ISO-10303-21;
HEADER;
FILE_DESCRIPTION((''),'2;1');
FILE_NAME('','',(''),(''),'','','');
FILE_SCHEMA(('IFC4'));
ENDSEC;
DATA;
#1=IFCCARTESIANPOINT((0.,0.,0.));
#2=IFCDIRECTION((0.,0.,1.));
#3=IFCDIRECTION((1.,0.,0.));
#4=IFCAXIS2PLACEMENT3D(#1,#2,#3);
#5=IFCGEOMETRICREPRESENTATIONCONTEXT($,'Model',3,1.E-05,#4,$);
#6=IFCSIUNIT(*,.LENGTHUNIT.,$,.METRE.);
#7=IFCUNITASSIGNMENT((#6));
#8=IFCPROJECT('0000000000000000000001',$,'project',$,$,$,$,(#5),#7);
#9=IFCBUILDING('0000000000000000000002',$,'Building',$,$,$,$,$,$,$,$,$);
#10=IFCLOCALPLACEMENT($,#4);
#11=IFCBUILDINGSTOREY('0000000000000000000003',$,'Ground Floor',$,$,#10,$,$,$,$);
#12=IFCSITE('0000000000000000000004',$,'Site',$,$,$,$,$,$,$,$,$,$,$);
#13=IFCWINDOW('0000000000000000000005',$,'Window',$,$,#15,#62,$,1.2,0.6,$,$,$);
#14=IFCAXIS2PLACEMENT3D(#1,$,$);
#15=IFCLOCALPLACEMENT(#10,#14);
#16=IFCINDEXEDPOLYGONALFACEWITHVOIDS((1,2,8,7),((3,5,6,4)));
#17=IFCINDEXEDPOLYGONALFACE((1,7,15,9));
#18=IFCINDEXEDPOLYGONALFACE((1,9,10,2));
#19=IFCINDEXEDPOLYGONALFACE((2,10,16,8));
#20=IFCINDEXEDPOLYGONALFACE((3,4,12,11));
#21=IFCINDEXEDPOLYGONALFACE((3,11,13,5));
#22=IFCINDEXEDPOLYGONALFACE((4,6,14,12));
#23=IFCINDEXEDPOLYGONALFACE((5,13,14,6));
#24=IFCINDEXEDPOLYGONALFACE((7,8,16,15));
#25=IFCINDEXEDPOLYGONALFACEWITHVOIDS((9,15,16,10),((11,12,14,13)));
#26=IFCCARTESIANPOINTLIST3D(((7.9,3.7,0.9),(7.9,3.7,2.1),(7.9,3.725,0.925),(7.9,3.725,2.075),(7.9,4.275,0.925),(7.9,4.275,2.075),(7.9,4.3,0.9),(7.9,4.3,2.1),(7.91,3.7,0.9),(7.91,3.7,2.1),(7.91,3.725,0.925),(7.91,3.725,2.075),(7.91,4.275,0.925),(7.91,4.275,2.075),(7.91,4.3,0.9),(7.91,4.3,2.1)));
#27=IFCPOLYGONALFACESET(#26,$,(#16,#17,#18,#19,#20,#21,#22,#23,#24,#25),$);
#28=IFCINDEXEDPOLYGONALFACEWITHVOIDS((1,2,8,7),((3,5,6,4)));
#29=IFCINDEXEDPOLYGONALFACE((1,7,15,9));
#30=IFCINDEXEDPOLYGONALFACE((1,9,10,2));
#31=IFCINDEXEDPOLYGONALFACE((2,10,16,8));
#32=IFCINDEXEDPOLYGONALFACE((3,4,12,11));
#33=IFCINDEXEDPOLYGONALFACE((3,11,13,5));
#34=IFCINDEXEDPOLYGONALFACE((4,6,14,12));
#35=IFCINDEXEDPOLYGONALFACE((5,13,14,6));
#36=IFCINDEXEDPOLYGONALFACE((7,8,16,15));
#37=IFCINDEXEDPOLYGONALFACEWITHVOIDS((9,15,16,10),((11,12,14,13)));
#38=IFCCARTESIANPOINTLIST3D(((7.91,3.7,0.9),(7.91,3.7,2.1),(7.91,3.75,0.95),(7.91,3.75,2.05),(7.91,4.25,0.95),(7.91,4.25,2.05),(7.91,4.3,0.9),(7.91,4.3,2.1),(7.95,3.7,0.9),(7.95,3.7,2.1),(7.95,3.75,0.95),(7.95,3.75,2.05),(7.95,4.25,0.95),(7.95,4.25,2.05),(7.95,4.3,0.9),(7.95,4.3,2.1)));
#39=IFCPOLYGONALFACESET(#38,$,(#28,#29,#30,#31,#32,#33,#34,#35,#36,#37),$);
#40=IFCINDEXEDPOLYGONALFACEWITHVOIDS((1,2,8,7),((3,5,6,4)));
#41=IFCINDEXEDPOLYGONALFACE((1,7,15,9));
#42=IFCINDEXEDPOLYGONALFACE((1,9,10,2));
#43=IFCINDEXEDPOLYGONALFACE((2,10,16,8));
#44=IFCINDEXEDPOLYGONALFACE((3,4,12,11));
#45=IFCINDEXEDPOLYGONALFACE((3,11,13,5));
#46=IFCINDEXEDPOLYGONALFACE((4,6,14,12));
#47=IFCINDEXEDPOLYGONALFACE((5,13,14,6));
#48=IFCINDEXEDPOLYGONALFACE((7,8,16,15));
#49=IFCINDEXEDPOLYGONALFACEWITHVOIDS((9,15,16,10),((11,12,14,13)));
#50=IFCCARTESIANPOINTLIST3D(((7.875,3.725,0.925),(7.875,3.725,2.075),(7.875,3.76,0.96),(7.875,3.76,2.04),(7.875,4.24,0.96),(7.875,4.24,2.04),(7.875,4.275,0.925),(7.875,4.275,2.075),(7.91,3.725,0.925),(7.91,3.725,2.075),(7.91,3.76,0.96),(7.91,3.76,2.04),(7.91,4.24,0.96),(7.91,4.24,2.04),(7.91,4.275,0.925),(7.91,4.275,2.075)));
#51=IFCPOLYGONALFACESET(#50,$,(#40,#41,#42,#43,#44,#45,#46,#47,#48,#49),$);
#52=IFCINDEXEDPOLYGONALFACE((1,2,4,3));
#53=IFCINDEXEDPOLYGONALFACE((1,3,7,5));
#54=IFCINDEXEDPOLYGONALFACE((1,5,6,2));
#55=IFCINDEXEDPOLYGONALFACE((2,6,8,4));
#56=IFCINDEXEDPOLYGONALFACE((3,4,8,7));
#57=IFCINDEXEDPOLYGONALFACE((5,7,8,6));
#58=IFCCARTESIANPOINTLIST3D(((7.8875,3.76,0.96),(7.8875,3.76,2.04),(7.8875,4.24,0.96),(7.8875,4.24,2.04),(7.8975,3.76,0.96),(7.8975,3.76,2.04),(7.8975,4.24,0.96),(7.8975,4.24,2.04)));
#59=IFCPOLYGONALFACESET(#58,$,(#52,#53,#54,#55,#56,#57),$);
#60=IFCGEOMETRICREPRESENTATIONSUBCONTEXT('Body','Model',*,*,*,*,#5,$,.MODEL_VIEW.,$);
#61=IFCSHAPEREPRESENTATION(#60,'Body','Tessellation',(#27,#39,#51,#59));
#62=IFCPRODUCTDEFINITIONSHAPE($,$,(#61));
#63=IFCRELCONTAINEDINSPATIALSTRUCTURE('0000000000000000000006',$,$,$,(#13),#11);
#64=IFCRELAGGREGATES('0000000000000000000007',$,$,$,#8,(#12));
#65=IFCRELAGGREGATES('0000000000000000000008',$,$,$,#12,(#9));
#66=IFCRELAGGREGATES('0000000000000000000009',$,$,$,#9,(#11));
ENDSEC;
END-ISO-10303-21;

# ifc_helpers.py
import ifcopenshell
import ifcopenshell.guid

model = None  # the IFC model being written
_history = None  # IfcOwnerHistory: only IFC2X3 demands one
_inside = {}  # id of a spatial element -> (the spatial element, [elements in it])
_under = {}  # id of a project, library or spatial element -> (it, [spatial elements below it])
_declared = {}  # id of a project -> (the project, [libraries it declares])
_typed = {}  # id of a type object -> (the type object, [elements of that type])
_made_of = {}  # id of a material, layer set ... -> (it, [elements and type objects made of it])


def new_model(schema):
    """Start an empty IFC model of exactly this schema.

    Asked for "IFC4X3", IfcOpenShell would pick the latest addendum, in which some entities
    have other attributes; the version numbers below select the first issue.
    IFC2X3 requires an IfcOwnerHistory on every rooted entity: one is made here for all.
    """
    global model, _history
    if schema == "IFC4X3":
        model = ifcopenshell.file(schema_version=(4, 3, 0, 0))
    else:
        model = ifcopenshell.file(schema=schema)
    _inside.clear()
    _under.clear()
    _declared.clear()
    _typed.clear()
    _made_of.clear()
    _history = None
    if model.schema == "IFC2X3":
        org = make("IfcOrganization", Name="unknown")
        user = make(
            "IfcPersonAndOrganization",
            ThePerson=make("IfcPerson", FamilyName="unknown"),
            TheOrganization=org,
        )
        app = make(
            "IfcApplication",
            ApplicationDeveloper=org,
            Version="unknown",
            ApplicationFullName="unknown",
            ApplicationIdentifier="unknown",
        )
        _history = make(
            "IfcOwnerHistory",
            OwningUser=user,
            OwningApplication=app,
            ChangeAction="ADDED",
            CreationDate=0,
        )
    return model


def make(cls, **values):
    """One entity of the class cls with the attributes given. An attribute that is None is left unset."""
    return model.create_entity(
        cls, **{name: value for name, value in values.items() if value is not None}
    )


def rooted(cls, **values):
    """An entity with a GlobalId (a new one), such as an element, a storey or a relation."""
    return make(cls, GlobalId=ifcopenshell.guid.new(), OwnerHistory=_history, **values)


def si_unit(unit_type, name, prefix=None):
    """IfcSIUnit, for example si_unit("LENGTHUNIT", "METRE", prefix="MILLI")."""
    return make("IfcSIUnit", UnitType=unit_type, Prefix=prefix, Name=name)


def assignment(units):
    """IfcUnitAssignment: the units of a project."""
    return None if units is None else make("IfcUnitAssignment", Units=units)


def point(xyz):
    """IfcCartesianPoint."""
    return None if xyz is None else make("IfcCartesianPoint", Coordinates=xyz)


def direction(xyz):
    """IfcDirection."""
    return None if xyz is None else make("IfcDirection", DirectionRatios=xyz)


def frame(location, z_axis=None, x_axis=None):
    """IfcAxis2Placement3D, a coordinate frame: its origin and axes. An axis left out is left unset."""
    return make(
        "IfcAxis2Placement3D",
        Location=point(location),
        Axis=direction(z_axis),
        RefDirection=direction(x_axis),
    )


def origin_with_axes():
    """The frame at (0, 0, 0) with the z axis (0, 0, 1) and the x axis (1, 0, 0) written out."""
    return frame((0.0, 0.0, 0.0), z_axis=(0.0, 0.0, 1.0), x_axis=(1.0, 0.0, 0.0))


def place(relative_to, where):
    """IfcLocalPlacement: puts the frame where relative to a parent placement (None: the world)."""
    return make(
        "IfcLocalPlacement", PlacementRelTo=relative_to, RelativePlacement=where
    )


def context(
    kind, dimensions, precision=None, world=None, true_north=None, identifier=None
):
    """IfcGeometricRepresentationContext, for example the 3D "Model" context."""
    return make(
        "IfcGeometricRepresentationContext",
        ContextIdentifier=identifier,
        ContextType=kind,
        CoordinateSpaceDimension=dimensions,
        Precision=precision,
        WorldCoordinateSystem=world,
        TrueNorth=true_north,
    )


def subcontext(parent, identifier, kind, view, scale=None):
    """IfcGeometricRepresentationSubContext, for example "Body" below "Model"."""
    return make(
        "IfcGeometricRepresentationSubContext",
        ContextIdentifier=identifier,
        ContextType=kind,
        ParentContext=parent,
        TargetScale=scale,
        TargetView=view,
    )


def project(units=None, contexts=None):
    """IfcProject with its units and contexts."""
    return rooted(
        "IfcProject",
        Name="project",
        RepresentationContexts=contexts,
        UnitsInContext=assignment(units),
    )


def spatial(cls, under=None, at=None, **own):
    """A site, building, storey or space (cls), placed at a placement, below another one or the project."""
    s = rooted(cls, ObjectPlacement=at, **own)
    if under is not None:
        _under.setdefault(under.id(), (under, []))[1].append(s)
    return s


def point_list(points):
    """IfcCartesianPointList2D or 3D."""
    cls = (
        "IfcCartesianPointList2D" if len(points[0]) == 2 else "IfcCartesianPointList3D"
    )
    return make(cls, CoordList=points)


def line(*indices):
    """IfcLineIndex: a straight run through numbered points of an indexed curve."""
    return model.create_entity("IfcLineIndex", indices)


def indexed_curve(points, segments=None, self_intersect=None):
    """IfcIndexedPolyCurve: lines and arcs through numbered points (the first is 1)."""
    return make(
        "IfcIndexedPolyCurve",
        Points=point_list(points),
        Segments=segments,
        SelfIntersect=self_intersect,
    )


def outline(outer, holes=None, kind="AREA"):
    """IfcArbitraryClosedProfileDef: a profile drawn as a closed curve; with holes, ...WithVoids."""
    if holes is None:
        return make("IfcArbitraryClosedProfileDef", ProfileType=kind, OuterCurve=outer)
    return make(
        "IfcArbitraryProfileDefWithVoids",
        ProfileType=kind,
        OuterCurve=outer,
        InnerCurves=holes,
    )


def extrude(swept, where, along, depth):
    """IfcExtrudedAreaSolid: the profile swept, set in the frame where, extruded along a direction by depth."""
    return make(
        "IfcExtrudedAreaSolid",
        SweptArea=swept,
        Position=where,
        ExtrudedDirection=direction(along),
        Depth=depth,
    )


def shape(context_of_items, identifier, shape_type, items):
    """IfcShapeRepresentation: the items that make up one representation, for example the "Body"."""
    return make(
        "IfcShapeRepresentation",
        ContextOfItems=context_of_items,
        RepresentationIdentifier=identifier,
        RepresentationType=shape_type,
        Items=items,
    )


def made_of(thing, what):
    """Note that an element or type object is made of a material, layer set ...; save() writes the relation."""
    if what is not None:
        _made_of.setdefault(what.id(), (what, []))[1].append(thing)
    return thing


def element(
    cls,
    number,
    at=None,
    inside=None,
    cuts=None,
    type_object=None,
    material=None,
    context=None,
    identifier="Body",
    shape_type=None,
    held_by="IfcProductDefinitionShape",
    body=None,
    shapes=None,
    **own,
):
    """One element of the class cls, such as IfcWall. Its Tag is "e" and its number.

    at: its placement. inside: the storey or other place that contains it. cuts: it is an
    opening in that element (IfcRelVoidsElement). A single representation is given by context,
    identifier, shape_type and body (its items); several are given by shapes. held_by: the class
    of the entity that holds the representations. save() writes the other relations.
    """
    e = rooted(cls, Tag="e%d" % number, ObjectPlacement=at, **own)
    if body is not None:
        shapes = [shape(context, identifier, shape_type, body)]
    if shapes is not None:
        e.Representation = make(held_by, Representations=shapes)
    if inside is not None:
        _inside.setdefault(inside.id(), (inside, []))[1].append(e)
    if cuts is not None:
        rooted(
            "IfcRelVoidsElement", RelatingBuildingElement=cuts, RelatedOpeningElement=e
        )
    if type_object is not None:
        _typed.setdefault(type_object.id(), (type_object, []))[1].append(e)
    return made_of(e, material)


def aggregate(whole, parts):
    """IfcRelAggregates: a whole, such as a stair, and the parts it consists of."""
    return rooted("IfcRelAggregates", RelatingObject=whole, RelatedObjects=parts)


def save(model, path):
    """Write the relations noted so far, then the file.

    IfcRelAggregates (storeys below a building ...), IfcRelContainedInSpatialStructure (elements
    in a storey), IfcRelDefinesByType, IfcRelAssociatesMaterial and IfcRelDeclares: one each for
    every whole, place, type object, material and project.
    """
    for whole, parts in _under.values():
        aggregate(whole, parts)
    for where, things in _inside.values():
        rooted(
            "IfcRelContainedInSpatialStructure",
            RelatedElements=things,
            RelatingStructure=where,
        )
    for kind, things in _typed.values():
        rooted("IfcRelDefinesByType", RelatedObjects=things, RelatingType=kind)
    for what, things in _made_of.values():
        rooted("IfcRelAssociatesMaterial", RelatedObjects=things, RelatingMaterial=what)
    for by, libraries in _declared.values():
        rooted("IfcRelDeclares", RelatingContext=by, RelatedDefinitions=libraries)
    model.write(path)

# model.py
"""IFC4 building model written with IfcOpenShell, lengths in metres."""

from ifc_helpers import new_model, si_unit, frame, origin_with_axes, place, context, subcontext, project, spatial, line, indexed_curve, outline, extrude, element, save


model = new_model("IFC4")

# Units and contexts
model_context = context("Model", 3, precision=1e-05, world=origin_with_axes())
body_context = subcontext(model_context, "Body", "Model", "MODEL_VIEW")
ifc_project = project(units=[si_unit("LENGTHUNIT", "METRE")], contexts=[model_context])

# Site, building, storey
site = spatial("IfcSite", under=ifc_project, Name="Site")
building = spatial("IfcBuilding", under=site, Name="Building")
storey_placement = place(None, origin_with_axes())
storey = spatial("IfcBuildingStorey", under=building, at=storey_placement, Name="Ground Floor")

# Window
window_1_placement = place(storey_placement, frame((8.0, 3.7, 0.9), z_axis=(0.0, 0.0, 1.0), x_axis=(0.0, 1.0, 0.0)))
element("IfcWindow", 1, at=window_1_placement, inside=storey, Name="Window", OverallHeight=1.2, OverallWidth=0.6, context=body_context, shape_type="SweptSolid", body=[
    extrude(outline(indexed_curve([(0.0, 0.0), (0.6, 0.0), (0.6, 1.2), (0.0, 1.2)], segments=[line(1, 2, 3, 4, 1)]), holes=[indexed_curve([(0.025, 0.025), (0.575, 0.025), (0.575, 1.175), (0.025, 1.175)], segments=[line(1, 2, 3, 4, 1)])]), frame((0.0, 0.09, 0.0), z_axis=(0.0, -1.0, 0.0), x_axis=(1.0, 0.0, 0.0)), (0.0, 0.0, -1.0), 0.01),
    extrude(outline(indexed_curve([(0.0, 0.0), (0.6, 0.0), (0.6, 1.2), (0.0, 1.2)], segments=[line(1, 2, 3, 4, 1)]), holes=[indexed_curve([(0.05, 0.05), (0.55, 0.05), (0.55, 1.15), (0.05, 1.15)], segments=[line(1, 2, 3, 4, 1)])]), frame((0.0, 0.05, 0.0), z_axis=(0.0, -1.0, 0.0), x_axis=(1.0, 0.0, 0.0)), (0.0, 0.0, -1.0), 0.04),
    extrude(outline(indexed_curve([(0.0, 0.0), (0.55, 0.0), (0.55, 1.15), (0.0, 1.15)], segments=[line(1, 2, 3, 4, 1)]), holes=[indexed_curve([(0.035, 0.035), (0.515, 0.035), (0.515, 1.115), (0.035, 1.115)], segments=[line(1, 2, 3, 4, 1)])]), frame((0.025, 0.09, 0.025), z_axis=(0.0, -1.0, 0.0), x_axis=(1.0, 0.0, 0.0)), (0.0, 0.0, -1.0), 0.035),
    extrude(outline(indexed_curve([(0.035, 0.035), (0.515, 0.035), (0.515, 1.115), (0.035, 1.115)], segments=[line(1, 2, 3, 4, 1)])), frame((0.025, 0.1025, 0.025), z_axis=(0.0, -1.0, 0.0), x_axis=(1.0, 0.0, 0.0)), (0.0, 0.0, -1.0), 0.01),
])

save(model, "model.ifc")
